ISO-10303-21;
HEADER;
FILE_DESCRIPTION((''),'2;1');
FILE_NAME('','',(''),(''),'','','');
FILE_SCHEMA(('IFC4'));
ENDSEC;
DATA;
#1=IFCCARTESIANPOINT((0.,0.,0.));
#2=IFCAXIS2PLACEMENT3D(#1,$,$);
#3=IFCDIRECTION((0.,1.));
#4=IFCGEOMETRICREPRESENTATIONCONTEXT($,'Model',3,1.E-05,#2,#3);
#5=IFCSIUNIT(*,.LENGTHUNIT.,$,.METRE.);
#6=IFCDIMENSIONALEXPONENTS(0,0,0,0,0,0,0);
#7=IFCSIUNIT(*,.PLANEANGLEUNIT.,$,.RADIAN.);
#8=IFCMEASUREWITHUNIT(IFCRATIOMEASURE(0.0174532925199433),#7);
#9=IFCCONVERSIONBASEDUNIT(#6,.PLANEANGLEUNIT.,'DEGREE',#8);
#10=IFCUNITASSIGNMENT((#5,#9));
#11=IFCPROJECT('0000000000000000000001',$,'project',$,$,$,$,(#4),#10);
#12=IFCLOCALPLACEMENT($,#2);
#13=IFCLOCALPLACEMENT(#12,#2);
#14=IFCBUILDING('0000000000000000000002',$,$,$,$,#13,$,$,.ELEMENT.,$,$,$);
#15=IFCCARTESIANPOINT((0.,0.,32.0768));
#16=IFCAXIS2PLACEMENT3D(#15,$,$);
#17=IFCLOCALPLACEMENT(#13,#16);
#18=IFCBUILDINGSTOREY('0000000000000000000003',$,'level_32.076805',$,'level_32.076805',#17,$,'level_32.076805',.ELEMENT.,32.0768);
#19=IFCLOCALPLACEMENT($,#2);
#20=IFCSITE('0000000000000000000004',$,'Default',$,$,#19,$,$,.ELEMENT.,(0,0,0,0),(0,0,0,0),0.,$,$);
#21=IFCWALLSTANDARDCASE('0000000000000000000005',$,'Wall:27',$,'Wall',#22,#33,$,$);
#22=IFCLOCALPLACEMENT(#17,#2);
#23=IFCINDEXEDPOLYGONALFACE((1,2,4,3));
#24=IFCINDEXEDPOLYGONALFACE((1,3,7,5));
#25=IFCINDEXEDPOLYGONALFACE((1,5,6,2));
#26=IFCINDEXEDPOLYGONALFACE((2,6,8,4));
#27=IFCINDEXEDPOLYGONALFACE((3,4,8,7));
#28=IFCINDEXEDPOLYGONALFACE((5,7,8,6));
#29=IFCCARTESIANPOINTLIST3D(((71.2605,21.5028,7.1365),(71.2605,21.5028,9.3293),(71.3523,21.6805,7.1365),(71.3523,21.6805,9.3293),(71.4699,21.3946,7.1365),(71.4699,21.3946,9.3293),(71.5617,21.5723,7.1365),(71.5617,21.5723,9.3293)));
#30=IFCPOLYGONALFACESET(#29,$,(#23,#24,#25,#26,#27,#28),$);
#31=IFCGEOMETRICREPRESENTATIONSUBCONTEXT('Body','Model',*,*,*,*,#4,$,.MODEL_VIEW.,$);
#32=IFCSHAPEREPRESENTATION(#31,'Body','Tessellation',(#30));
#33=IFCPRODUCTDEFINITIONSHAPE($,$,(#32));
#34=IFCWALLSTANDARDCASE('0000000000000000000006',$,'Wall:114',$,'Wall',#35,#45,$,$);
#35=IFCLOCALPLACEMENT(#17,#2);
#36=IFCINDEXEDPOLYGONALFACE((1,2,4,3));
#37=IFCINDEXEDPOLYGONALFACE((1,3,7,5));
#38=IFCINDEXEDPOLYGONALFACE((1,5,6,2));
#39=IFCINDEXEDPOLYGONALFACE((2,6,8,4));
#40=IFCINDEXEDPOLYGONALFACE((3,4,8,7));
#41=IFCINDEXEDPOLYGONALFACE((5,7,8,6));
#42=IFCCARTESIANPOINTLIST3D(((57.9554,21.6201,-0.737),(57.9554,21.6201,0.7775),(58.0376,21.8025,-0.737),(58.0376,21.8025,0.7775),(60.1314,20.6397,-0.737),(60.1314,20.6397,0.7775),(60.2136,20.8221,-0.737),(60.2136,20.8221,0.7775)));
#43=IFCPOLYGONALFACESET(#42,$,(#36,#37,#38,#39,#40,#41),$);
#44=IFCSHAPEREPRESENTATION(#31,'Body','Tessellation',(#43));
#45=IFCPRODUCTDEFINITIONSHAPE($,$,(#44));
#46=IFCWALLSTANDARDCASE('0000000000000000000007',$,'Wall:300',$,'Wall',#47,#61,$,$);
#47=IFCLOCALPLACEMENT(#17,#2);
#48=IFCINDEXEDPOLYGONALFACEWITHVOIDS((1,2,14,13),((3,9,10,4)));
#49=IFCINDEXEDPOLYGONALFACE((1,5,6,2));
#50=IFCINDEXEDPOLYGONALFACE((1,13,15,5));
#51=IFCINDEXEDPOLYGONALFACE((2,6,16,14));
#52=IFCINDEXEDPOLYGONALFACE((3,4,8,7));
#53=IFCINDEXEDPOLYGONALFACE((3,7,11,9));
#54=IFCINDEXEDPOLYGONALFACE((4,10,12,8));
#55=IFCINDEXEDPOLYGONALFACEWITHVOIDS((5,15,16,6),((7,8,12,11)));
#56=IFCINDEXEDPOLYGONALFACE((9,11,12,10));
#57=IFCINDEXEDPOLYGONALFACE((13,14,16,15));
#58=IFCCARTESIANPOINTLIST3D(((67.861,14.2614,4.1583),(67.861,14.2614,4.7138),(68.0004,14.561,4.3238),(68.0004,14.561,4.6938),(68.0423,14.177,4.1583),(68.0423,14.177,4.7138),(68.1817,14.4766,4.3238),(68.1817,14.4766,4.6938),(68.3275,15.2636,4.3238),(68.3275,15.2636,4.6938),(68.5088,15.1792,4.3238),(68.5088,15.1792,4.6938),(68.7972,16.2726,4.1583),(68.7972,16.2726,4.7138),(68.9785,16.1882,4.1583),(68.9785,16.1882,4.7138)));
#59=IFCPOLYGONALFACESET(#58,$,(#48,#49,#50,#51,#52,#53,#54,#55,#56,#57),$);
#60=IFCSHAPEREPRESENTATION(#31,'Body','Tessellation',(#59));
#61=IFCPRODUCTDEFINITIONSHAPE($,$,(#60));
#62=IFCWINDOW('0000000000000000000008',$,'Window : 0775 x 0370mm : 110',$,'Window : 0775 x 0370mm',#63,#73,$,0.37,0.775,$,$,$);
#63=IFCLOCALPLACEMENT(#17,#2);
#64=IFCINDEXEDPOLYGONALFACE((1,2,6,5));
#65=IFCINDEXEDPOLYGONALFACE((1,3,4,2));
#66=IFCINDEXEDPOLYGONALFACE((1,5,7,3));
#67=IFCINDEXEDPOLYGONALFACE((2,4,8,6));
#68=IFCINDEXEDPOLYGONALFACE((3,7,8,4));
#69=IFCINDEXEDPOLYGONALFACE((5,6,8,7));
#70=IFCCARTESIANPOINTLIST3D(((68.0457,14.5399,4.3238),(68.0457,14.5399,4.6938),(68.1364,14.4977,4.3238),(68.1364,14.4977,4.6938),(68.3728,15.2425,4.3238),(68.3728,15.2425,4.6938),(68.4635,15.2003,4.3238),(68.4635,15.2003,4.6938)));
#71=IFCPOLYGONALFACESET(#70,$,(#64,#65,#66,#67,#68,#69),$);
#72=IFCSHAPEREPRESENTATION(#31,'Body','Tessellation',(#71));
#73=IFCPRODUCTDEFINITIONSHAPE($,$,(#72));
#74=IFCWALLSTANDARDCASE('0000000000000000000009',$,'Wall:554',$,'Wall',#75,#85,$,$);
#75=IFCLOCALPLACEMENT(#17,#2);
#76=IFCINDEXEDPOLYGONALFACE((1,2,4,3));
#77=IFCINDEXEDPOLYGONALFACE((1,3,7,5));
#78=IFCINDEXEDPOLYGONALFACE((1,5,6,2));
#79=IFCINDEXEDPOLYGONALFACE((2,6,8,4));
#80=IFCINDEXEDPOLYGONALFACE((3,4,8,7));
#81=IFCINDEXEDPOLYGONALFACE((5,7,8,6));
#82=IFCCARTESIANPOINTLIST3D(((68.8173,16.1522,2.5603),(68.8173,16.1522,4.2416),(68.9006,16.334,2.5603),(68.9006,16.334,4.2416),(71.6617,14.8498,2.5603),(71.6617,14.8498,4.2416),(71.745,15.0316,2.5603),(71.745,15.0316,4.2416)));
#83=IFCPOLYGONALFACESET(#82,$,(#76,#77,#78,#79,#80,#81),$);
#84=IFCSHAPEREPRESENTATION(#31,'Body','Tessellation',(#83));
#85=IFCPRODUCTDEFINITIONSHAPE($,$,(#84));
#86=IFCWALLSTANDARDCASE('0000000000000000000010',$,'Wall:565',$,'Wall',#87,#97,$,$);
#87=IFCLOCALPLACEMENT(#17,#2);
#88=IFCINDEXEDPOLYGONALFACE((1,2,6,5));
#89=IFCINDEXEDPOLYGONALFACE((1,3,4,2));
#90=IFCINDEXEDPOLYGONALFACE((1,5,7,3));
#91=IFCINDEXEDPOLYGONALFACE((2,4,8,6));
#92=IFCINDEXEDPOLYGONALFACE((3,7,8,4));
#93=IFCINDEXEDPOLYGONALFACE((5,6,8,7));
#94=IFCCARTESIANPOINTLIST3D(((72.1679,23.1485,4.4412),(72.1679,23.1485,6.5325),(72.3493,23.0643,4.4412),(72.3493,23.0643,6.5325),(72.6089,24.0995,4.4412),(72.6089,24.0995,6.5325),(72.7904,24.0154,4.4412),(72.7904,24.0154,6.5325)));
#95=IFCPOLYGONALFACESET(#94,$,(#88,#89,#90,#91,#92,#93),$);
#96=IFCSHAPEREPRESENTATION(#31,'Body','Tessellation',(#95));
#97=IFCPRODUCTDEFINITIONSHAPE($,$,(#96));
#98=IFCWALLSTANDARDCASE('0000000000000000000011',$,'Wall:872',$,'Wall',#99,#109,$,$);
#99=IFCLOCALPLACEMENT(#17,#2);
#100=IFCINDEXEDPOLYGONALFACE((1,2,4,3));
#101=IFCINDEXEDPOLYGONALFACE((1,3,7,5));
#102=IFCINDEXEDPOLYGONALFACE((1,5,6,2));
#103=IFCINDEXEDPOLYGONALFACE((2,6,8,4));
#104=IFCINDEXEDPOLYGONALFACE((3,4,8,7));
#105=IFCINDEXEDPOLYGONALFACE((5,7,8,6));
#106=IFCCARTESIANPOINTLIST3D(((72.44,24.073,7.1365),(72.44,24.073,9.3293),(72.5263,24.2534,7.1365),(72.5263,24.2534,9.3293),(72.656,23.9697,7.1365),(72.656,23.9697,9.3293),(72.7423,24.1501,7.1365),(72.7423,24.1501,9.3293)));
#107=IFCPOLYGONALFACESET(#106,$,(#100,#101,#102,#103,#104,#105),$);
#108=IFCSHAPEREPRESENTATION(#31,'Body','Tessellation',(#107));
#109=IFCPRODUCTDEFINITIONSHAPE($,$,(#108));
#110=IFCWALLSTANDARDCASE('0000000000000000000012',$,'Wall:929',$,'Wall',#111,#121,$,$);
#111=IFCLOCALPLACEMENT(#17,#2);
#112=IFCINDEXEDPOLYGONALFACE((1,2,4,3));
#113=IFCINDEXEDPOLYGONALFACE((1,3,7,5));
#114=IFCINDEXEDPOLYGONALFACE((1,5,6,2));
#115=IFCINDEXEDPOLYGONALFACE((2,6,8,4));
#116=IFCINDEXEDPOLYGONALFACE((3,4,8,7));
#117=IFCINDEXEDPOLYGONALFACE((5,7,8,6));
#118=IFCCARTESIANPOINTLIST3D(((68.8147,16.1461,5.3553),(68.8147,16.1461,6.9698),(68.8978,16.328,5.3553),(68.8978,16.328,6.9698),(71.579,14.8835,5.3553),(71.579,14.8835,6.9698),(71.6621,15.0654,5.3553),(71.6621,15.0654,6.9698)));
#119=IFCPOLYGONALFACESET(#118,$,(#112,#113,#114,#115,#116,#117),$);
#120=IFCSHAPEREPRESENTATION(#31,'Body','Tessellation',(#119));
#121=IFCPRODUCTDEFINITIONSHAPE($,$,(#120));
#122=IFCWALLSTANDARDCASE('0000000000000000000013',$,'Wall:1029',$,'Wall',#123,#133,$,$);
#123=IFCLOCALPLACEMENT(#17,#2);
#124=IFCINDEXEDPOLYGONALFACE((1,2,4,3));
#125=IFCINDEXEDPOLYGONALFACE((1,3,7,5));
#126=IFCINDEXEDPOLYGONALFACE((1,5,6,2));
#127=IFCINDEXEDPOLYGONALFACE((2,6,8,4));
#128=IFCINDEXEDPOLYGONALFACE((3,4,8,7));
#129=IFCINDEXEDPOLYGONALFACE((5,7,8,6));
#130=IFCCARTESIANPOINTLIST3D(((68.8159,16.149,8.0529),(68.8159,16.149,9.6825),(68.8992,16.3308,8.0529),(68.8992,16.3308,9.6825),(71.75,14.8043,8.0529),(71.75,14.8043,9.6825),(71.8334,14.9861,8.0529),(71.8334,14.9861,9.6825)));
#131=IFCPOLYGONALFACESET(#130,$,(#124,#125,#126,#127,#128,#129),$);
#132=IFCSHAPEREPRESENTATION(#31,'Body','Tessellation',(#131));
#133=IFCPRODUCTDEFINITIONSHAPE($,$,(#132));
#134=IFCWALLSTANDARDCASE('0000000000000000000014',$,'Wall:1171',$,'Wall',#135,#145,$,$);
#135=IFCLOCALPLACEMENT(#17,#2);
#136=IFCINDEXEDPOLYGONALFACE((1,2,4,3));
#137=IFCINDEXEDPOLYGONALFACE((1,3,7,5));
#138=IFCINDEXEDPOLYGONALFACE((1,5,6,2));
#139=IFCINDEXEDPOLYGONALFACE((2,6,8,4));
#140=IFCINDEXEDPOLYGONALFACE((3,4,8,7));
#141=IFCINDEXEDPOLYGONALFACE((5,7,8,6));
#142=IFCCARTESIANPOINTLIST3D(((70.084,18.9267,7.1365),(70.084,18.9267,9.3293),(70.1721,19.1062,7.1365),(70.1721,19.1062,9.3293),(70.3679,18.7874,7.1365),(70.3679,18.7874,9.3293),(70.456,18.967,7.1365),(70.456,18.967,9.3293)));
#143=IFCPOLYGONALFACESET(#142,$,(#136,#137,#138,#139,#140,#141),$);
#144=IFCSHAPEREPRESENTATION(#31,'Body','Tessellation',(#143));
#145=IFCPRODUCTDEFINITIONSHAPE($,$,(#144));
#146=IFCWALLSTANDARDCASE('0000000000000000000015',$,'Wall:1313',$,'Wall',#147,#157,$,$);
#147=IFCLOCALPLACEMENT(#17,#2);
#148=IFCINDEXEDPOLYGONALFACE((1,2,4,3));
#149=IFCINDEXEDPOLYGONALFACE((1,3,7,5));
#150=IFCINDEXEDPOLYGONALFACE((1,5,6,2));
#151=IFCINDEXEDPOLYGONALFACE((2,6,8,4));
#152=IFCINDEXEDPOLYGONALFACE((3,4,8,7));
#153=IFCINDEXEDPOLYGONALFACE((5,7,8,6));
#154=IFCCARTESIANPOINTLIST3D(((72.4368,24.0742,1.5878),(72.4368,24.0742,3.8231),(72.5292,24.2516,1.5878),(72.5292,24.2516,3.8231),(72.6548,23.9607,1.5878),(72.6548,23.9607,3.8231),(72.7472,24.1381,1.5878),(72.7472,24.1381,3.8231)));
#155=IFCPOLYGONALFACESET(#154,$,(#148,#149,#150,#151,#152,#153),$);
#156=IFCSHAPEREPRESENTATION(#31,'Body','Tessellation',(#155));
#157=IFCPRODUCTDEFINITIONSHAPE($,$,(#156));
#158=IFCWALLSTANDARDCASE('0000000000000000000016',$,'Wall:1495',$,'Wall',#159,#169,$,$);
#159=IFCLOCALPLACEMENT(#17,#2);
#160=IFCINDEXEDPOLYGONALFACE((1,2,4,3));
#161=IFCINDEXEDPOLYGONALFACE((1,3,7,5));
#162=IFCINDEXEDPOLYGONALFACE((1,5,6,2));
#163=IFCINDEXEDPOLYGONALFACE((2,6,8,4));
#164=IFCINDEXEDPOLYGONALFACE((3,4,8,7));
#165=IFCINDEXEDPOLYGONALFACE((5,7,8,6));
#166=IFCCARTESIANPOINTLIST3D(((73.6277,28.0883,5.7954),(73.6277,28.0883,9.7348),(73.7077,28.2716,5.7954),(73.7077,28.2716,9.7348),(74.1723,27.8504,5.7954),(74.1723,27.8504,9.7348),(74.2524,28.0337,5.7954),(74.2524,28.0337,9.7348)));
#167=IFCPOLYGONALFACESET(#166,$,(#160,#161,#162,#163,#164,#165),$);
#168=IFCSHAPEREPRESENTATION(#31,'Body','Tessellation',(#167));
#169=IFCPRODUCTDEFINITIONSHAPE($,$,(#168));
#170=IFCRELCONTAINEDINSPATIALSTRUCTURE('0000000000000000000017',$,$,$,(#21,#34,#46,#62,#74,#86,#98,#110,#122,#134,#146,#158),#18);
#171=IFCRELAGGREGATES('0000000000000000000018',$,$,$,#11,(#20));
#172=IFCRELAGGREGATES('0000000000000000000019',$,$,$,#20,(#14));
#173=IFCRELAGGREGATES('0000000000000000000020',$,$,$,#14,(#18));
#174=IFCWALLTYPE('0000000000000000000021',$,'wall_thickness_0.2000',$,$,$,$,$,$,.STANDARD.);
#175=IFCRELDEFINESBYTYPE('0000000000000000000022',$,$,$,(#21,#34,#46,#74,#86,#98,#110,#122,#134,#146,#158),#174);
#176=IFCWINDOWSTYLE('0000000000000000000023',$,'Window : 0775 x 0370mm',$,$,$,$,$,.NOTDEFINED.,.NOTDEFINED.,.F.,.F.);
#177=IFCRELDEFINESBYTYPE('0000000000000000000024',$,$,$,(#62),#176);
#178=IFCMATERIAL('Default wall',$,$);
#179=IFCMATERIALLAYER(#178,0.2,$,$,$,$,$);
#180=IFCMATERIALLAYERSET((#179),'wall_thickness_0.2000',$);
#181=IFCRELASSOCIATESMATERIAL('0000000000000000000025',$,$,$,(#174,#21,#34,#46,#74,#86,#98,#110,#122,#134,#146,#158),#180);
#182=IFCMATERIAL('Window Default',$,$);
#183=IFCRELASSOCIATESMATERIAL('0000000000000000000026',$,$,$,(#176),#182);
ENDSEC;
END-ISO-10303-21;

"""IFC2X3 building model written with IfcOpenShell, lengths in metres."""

from ifc_helpers import new_model, entity, si_unit, converted_unit, direction, frame, frame_2d, origin, origin_2d_with_axis, place, context, subcontext, project, spatial, polyline, rectangle, outline, extrude, source, transform, mapped, material, layer, layer_set, layer_usage, type_object, type_shapes, element, fill, save


model = new_model("IFC2X3")

# Units and contexts
model_context = context("Model", 3, precision=1e-05, world=origin(), true_north=direction((0.0, 1.0)))
body_context = subcontext(model_context, "Body", "Model", "MODEL_VIEW")
ifc_project = project(units=[si_unit("LENGTHUNIT", "METRE"), converted_unit("PLANEANGLEUNIT", "DEGREE", entity("IfcRatioMeasure", 0.0174532925199433), si_unit("PLANEANGLEUNIT", "RADIAN"), dimensions=[0, 0, 0, 0, 0, 0, 0])], contexts=[model_context])

# Site, building, storey
site_placement = place(None, origin())
site = spatial("IfcSite", under=ifc_project, at=site_placement, Name="Default", CompositionType="ELEMENT", RefLatitude=(0, 0, 0, 0), RefLongitude=(0, 0, 0, 0), RefElevation=0.0)
placement_1 = place(None, origin())
building_placement = place(placement_1, origin())
building = spatial("IfcBuilding", under=site, at=building_placement, CompositionType="ELEMENT")
storey_placement = place(building_placement, frame((0.0, 0.0, 32.0768)))
storey = spatial("IfcBuildingStorey", under=building, at=storey_placement, Name="level_32.076805", ObjectType="level_32.076805", LongName="level_32.076805", CompositionType="ELEMENT", Elevation=32.0768)

# Walls
ifc_material_1 = material(Name="Default wall")
ifc_layer = layer(ifc_material_1, 0.2)
ifc_layer_set = layer_set([ifc_layer], Name="wall_thickness_0.2000")
ifc_layer_usage = layer_usage(ifc_layer_set, "AXIS2", "POSITIVE", -0.1)
wall_type = type_object("IfcWallType", Name="wall_thickness_0.2000", PredefinedType="STANDARD", material=ifc_layer_set)
placement_2 = place(building_placement, frame((0.0, 0.0, 39.2133)))
wall_1_placement = place(placement_2, frame((71.5158, 21.4835, 0.0), z_axis=(0.0, 0.0, 1.0), x_axis=(-0.888466, 0.458942, 0.0)))
element("IfcWallStandardCase", 1, at=wall_1_placement, inside=storey, type_object=wall_type, material=ifc_layer_usage, Name="Wall:27", ObjectType="Wall", context=body_context, shape_type="SweptSolid", body=[
    extrude(outline(polyline([(0.2356, -0.1), (0.2356, 0.1), (0.0, 0.1), (0.0, -0.1), (0.2356, -0.1)])), origin(), (0.0, 0.0, 1.0), 2.1928),
])
placement_3 = place(building_placement, frame((0.0, 0.0, 31.3398)))
wall_2_placement = place(placement_3, frame((57.9965, 21.7113, 0.0), z_axis=(0.0, 0.0, 1.0), x_axis=(0.911734, -0.41078, 0.0)))
element("IfcWallStandardCase", 2, at=wall_2_placement, inside=storey, type_object=wall_type, material=ifc_layer_usage, Name="Wall:114", ObjectType="Wall", context=body_context, shape_type="SweptSolid", body=[
    extrude(outline(polyline([(2.3867, -0.1), (2.3867, 0.1), (0.0, 0.1), (0.0, -0.1), (2.3867, -0.1)])), origin(), (0.0, 0.0, 1.0), 1.5146),
])

# Wall, opening, window
placement_4 = place(building_placement, frame((0.0, 0.0, 36.2351)))
wall_3_placement = place(placement_4, frame((67.9516, 14.2192, 0.0), z_axis=(0.0, 0.0, 1.0), x_axis=(0.422036, 0.906579, 0.0)))
wall_3 = element("IfcWallStandardCase", 3, at=wall_3_placement, inside=storey, type_object=wall_type, material=ifc_layer_usage, Name="Wall:300", ObjectType="Wall", context=body_context, shape_type="SweptSolid", body=[
    extrude(outline(polyline([(2.2184, -0.1), (2.2184, 0.1), (0.0, 0.1), (0.0, -0.1), (2.2184, -0.1)])), origin(), (0.0, 0.0, 1.0), 0.5555),
])
opening_1_placement = place(wall_3_placement, frame((0.3305, -0.1, 0.1655)))
opening_1 = element("IfcOpeningElement", 4, at=opening_1_placement, cuts=wall_3, ObjectType="Opening", context=body_context, shape_type="SweptSolid", body=[
    extrude(rectangle(XDim=0.775, YDim=0.37, at=frame_2d((0.185, 0.3875), x_axis=(0.0, 1.0))), frame((0.0, 0.0, 0.0), z_axis=(0.0, 1.0, 0.0), x_axis=(0.0, 0.0, 1.0)), (0.0, 0.0, 1.0), 0.2),
])
ifc_material_2 = material(Name="Window Default")
window_style_1 = type_object("IfcWindowStyle", Name="Window : 0775 x 0370mm", ConstructionType="NOTDEFINED", OperationType="NOTDEFINED", ParameterTakesPrecedence=False, Sizeable=False, material=ifc_material_2)
shared_shape_1 = source(origin(), body_context, "Body", "SweptSolid", [
    extrude(rectangle(XDim=0.1, YDim=0.775, at=origin_2d_with_axis()), frame((0.3875, 0.1, 0.0), z_axis=(0.0, 0.0, 1.0), x_axis=(0.0, 1.0, 0.0)), (0.0, 0.0, 1.0), 0.37),
])
type_shapes(window_style_1, [shared_shape_1])
window_1_placement = place(opening_1_placement, origin())
window_1 = element("IfcWindow", 5, at=window_1_placement, inside=storey, type_object=window_style_1, Name="Window : 0775 x 0370mm : 110", ObjectType="Window : 0775 x 0370mm", OverallHeight=0.37, OverallWidth=0.775, context=body_context, shape_type="MappedRepresentation", body=[
    mapped(shared_shape_1, transform((0.0, 0.0, 0.0), scale=1.0)),
])
fill(opening_1, window_1)

# Walls
placement_5 = place(building_placement, frame((0.0, 0.0, 34.6371)))
wall_4_placement = place(placement_5, frame((68.859, 16.2431, 0.0), z_axis=(0.0, 0.0, 1.0), x_axis=(0.909219, -0.416318, 0.0)))
element("IfcWallStandardCase", 6, at=wall_4_placement, inside=storey, type_object=wall_type, material=ifc_layer_usage, Name="Wall:554", ObjectType="Wall", context=body_context, shape_type="SweptSolid", body=[
    extrude(outline(polyline([(3.1284, -0.1), (3.1284, 0.1), (0.0, 0.1), (0.0, -0.1), (3.1284, -0.1)])), origin(), (0.0, 0.0, 1.0), 1.6814),
])
placement_6 = place(building_placement, frame((0.0, 0.0, 36.518)))
wall_5_placement = place(placement_6, frame((72.2586, 23.1064, 0.0), z_axis=(0.0, 0.0, 1.0), x_axis=(0.420704, 0.907198, 0.0)))
element("IfcWallStandardCase", 7, at=wall_5_placement, inside=storey, type_object=wall_type, material=ifc_layer_usage, Name="Wall:565", ObjectType="Wall", context=body_context, shape_type="SweptSolid", body=[
    extrude(outline(polyline([(1.0484, -0.1), (1.0484, 0.1), (0.0, 0.1), (0.0, -0.1), (1.0484, -0.1)])), origin(), (0.0, 0.0, 1.0), 2.0913),
])
placement_7 = place(building_placement, frame((0.0, 0.0, 39.2133)))
wall_6_placement = place(placement_7, frame((72.4832, 24.1632, 0.0), z_axis=(0.0, 0.0, 1.0), x_axis=(0.902019, -0.431697, 0.0)))
element("IfcWallStandardCase", 8, at=wall_6_placement, inside=storey, type_object=wall_type, material=ifc_layer_usage, Name="Wall:872", ObjectType="Wall", context=body_context, shape_type="SweptSolid", body=[
    extrude(outline(polyline([(0.2394, -0.1), (0.2394, 0.1), (0.0, 0.1), (0.0, -0.1), (0.2394, -0.1)])), origin(), (0.0, 0.0, 1.0), 2.1928),
])
placement_8 = place(building_placement, frame((0.0, 0.0, 37.4321)))
wall_7_placement = place(placement_8, frame((68.8562, 16.2371, 0.0), z_axis=(0.0, 0.0, 1.0), x_axis=(0.909609, -0.415465, 0.0)))
element("IfcWallStandardCase", 9, at=wall_7_placement, inside=storey, type_object=wall_type, material=ifc_layer_usage, Name="Wall:929", ObjectType="Wall", context=body_context, shape_type="SweptSolid", body=[
    extrude(outline(polyline([(3.0391, -0.1), (3.0391, 0.1), (0.0, 0.1), (0.0, -0.1), (3.0391, -0.1)])), origin(), (0.0, 0.0, 1.0), 1.6145),
])
placement_9 = place(building_placement, frame((0.0, 0.0, 40.1297)))
wall_8_placement = place(placement_9, frame((68.8575, 16.2399, 0.0), z_axis=(0.0, 0.0, 1.0), x_axis=(0.90908, -0.416621, 0.0)))
element("IfcWallStandardCase", 10, at=wall_8_placement, inside=storey, type_object=wall_type, material=ifc_layer_usage, Name="Wall:1029", ObjectType="Wall", context=body_context, shape_type="SweptSolid", body=[
    extrude(outline(polyline([(3.2276, -0.1), (3.2276, 0.1), (0.0, 0.1), (0.0, -0.1), (3.2276, -0.1)])), origin(), (0.0, 0.0, 1.0), 1.6296),
])
placement_10 = place(building_placement, frame((0.0, 0.0, 39.2133)))
wall_9_placement = place(placement_10, frame((70.412, 18.8772, 0.0), z_axis=(0.0, 0.0, 1.0), x_axis=(-0.897813, 0.440378, 0.0)))
element("IfcWallStandardCase", 11, at=wall_9_placement, inside=storey, type_object=wall_type, material=ifc_layer_usage, Name="Wall:1171", ObjectType="Wall", context=body_context, shape_type="SweptSolid", body=[
    extrude(outline(polyline([(0.3162, -0.1), (0.3162, 0.1), (0.0, 0.1), (0.0, -0.1), (0.3162, -0.1)])), origin(), (0.0, 0.0, 1.0), 2.1928),
])
placement_11 = place(building_placement, frame((0.0, 0.0, 33.6646)))
wall_10_placement = place(placement_11, frame((72.701, 24.0494, 0.0), z_axis=(0.0, 0.0, 1.0), x_axis=(-0.887009, 0.461753, 0.0)))
element("IfcWallStandardCase", 12, at=wall_10_placement, inside=storey, type_object=wall_type, material=ifc_layer_usage, Name="Wall:1313", ObjectType="Wall", context=body_context, shape_type="SweptSolid", body=[
    extrude(outline(polyline([(0.2457, -0.1), (0.2457, 0.1), (0.0, 0.1), (0.0, -0.1), (0.2457, -0.1)])), origin(), (0.0, 0.0, 1.0), 2.2353),
])
placement_12 = place(building_placement, frame((0.0, 0.0, 37.8722)))
wall_11_placement = place(placement_12, frame((74.2124, 27.9421, 0.0), z_axis=(0.0, 0.0, 1.0), x_axis=(-0.916434, 0.400186, 0.0)))
element("IfcWallStandardCase", 13, at=wall_11_placement, inside=storey, type_object=wall_type, material=ifc_layer_usage, Name="Wall:1495", ObjectType="Wall", context=body_context, shape_type="SweptSolid", body=[
    extrude(outline(polyline([(0.5943, -0.1), (0.5943, 0.1), (0.0, 0.1), (0.0, -0.1), (0.5943, -0.1)])), origin(), (0.0, 0.0, 1.0), 3.9394),
])

save(model, "model.ifc")
